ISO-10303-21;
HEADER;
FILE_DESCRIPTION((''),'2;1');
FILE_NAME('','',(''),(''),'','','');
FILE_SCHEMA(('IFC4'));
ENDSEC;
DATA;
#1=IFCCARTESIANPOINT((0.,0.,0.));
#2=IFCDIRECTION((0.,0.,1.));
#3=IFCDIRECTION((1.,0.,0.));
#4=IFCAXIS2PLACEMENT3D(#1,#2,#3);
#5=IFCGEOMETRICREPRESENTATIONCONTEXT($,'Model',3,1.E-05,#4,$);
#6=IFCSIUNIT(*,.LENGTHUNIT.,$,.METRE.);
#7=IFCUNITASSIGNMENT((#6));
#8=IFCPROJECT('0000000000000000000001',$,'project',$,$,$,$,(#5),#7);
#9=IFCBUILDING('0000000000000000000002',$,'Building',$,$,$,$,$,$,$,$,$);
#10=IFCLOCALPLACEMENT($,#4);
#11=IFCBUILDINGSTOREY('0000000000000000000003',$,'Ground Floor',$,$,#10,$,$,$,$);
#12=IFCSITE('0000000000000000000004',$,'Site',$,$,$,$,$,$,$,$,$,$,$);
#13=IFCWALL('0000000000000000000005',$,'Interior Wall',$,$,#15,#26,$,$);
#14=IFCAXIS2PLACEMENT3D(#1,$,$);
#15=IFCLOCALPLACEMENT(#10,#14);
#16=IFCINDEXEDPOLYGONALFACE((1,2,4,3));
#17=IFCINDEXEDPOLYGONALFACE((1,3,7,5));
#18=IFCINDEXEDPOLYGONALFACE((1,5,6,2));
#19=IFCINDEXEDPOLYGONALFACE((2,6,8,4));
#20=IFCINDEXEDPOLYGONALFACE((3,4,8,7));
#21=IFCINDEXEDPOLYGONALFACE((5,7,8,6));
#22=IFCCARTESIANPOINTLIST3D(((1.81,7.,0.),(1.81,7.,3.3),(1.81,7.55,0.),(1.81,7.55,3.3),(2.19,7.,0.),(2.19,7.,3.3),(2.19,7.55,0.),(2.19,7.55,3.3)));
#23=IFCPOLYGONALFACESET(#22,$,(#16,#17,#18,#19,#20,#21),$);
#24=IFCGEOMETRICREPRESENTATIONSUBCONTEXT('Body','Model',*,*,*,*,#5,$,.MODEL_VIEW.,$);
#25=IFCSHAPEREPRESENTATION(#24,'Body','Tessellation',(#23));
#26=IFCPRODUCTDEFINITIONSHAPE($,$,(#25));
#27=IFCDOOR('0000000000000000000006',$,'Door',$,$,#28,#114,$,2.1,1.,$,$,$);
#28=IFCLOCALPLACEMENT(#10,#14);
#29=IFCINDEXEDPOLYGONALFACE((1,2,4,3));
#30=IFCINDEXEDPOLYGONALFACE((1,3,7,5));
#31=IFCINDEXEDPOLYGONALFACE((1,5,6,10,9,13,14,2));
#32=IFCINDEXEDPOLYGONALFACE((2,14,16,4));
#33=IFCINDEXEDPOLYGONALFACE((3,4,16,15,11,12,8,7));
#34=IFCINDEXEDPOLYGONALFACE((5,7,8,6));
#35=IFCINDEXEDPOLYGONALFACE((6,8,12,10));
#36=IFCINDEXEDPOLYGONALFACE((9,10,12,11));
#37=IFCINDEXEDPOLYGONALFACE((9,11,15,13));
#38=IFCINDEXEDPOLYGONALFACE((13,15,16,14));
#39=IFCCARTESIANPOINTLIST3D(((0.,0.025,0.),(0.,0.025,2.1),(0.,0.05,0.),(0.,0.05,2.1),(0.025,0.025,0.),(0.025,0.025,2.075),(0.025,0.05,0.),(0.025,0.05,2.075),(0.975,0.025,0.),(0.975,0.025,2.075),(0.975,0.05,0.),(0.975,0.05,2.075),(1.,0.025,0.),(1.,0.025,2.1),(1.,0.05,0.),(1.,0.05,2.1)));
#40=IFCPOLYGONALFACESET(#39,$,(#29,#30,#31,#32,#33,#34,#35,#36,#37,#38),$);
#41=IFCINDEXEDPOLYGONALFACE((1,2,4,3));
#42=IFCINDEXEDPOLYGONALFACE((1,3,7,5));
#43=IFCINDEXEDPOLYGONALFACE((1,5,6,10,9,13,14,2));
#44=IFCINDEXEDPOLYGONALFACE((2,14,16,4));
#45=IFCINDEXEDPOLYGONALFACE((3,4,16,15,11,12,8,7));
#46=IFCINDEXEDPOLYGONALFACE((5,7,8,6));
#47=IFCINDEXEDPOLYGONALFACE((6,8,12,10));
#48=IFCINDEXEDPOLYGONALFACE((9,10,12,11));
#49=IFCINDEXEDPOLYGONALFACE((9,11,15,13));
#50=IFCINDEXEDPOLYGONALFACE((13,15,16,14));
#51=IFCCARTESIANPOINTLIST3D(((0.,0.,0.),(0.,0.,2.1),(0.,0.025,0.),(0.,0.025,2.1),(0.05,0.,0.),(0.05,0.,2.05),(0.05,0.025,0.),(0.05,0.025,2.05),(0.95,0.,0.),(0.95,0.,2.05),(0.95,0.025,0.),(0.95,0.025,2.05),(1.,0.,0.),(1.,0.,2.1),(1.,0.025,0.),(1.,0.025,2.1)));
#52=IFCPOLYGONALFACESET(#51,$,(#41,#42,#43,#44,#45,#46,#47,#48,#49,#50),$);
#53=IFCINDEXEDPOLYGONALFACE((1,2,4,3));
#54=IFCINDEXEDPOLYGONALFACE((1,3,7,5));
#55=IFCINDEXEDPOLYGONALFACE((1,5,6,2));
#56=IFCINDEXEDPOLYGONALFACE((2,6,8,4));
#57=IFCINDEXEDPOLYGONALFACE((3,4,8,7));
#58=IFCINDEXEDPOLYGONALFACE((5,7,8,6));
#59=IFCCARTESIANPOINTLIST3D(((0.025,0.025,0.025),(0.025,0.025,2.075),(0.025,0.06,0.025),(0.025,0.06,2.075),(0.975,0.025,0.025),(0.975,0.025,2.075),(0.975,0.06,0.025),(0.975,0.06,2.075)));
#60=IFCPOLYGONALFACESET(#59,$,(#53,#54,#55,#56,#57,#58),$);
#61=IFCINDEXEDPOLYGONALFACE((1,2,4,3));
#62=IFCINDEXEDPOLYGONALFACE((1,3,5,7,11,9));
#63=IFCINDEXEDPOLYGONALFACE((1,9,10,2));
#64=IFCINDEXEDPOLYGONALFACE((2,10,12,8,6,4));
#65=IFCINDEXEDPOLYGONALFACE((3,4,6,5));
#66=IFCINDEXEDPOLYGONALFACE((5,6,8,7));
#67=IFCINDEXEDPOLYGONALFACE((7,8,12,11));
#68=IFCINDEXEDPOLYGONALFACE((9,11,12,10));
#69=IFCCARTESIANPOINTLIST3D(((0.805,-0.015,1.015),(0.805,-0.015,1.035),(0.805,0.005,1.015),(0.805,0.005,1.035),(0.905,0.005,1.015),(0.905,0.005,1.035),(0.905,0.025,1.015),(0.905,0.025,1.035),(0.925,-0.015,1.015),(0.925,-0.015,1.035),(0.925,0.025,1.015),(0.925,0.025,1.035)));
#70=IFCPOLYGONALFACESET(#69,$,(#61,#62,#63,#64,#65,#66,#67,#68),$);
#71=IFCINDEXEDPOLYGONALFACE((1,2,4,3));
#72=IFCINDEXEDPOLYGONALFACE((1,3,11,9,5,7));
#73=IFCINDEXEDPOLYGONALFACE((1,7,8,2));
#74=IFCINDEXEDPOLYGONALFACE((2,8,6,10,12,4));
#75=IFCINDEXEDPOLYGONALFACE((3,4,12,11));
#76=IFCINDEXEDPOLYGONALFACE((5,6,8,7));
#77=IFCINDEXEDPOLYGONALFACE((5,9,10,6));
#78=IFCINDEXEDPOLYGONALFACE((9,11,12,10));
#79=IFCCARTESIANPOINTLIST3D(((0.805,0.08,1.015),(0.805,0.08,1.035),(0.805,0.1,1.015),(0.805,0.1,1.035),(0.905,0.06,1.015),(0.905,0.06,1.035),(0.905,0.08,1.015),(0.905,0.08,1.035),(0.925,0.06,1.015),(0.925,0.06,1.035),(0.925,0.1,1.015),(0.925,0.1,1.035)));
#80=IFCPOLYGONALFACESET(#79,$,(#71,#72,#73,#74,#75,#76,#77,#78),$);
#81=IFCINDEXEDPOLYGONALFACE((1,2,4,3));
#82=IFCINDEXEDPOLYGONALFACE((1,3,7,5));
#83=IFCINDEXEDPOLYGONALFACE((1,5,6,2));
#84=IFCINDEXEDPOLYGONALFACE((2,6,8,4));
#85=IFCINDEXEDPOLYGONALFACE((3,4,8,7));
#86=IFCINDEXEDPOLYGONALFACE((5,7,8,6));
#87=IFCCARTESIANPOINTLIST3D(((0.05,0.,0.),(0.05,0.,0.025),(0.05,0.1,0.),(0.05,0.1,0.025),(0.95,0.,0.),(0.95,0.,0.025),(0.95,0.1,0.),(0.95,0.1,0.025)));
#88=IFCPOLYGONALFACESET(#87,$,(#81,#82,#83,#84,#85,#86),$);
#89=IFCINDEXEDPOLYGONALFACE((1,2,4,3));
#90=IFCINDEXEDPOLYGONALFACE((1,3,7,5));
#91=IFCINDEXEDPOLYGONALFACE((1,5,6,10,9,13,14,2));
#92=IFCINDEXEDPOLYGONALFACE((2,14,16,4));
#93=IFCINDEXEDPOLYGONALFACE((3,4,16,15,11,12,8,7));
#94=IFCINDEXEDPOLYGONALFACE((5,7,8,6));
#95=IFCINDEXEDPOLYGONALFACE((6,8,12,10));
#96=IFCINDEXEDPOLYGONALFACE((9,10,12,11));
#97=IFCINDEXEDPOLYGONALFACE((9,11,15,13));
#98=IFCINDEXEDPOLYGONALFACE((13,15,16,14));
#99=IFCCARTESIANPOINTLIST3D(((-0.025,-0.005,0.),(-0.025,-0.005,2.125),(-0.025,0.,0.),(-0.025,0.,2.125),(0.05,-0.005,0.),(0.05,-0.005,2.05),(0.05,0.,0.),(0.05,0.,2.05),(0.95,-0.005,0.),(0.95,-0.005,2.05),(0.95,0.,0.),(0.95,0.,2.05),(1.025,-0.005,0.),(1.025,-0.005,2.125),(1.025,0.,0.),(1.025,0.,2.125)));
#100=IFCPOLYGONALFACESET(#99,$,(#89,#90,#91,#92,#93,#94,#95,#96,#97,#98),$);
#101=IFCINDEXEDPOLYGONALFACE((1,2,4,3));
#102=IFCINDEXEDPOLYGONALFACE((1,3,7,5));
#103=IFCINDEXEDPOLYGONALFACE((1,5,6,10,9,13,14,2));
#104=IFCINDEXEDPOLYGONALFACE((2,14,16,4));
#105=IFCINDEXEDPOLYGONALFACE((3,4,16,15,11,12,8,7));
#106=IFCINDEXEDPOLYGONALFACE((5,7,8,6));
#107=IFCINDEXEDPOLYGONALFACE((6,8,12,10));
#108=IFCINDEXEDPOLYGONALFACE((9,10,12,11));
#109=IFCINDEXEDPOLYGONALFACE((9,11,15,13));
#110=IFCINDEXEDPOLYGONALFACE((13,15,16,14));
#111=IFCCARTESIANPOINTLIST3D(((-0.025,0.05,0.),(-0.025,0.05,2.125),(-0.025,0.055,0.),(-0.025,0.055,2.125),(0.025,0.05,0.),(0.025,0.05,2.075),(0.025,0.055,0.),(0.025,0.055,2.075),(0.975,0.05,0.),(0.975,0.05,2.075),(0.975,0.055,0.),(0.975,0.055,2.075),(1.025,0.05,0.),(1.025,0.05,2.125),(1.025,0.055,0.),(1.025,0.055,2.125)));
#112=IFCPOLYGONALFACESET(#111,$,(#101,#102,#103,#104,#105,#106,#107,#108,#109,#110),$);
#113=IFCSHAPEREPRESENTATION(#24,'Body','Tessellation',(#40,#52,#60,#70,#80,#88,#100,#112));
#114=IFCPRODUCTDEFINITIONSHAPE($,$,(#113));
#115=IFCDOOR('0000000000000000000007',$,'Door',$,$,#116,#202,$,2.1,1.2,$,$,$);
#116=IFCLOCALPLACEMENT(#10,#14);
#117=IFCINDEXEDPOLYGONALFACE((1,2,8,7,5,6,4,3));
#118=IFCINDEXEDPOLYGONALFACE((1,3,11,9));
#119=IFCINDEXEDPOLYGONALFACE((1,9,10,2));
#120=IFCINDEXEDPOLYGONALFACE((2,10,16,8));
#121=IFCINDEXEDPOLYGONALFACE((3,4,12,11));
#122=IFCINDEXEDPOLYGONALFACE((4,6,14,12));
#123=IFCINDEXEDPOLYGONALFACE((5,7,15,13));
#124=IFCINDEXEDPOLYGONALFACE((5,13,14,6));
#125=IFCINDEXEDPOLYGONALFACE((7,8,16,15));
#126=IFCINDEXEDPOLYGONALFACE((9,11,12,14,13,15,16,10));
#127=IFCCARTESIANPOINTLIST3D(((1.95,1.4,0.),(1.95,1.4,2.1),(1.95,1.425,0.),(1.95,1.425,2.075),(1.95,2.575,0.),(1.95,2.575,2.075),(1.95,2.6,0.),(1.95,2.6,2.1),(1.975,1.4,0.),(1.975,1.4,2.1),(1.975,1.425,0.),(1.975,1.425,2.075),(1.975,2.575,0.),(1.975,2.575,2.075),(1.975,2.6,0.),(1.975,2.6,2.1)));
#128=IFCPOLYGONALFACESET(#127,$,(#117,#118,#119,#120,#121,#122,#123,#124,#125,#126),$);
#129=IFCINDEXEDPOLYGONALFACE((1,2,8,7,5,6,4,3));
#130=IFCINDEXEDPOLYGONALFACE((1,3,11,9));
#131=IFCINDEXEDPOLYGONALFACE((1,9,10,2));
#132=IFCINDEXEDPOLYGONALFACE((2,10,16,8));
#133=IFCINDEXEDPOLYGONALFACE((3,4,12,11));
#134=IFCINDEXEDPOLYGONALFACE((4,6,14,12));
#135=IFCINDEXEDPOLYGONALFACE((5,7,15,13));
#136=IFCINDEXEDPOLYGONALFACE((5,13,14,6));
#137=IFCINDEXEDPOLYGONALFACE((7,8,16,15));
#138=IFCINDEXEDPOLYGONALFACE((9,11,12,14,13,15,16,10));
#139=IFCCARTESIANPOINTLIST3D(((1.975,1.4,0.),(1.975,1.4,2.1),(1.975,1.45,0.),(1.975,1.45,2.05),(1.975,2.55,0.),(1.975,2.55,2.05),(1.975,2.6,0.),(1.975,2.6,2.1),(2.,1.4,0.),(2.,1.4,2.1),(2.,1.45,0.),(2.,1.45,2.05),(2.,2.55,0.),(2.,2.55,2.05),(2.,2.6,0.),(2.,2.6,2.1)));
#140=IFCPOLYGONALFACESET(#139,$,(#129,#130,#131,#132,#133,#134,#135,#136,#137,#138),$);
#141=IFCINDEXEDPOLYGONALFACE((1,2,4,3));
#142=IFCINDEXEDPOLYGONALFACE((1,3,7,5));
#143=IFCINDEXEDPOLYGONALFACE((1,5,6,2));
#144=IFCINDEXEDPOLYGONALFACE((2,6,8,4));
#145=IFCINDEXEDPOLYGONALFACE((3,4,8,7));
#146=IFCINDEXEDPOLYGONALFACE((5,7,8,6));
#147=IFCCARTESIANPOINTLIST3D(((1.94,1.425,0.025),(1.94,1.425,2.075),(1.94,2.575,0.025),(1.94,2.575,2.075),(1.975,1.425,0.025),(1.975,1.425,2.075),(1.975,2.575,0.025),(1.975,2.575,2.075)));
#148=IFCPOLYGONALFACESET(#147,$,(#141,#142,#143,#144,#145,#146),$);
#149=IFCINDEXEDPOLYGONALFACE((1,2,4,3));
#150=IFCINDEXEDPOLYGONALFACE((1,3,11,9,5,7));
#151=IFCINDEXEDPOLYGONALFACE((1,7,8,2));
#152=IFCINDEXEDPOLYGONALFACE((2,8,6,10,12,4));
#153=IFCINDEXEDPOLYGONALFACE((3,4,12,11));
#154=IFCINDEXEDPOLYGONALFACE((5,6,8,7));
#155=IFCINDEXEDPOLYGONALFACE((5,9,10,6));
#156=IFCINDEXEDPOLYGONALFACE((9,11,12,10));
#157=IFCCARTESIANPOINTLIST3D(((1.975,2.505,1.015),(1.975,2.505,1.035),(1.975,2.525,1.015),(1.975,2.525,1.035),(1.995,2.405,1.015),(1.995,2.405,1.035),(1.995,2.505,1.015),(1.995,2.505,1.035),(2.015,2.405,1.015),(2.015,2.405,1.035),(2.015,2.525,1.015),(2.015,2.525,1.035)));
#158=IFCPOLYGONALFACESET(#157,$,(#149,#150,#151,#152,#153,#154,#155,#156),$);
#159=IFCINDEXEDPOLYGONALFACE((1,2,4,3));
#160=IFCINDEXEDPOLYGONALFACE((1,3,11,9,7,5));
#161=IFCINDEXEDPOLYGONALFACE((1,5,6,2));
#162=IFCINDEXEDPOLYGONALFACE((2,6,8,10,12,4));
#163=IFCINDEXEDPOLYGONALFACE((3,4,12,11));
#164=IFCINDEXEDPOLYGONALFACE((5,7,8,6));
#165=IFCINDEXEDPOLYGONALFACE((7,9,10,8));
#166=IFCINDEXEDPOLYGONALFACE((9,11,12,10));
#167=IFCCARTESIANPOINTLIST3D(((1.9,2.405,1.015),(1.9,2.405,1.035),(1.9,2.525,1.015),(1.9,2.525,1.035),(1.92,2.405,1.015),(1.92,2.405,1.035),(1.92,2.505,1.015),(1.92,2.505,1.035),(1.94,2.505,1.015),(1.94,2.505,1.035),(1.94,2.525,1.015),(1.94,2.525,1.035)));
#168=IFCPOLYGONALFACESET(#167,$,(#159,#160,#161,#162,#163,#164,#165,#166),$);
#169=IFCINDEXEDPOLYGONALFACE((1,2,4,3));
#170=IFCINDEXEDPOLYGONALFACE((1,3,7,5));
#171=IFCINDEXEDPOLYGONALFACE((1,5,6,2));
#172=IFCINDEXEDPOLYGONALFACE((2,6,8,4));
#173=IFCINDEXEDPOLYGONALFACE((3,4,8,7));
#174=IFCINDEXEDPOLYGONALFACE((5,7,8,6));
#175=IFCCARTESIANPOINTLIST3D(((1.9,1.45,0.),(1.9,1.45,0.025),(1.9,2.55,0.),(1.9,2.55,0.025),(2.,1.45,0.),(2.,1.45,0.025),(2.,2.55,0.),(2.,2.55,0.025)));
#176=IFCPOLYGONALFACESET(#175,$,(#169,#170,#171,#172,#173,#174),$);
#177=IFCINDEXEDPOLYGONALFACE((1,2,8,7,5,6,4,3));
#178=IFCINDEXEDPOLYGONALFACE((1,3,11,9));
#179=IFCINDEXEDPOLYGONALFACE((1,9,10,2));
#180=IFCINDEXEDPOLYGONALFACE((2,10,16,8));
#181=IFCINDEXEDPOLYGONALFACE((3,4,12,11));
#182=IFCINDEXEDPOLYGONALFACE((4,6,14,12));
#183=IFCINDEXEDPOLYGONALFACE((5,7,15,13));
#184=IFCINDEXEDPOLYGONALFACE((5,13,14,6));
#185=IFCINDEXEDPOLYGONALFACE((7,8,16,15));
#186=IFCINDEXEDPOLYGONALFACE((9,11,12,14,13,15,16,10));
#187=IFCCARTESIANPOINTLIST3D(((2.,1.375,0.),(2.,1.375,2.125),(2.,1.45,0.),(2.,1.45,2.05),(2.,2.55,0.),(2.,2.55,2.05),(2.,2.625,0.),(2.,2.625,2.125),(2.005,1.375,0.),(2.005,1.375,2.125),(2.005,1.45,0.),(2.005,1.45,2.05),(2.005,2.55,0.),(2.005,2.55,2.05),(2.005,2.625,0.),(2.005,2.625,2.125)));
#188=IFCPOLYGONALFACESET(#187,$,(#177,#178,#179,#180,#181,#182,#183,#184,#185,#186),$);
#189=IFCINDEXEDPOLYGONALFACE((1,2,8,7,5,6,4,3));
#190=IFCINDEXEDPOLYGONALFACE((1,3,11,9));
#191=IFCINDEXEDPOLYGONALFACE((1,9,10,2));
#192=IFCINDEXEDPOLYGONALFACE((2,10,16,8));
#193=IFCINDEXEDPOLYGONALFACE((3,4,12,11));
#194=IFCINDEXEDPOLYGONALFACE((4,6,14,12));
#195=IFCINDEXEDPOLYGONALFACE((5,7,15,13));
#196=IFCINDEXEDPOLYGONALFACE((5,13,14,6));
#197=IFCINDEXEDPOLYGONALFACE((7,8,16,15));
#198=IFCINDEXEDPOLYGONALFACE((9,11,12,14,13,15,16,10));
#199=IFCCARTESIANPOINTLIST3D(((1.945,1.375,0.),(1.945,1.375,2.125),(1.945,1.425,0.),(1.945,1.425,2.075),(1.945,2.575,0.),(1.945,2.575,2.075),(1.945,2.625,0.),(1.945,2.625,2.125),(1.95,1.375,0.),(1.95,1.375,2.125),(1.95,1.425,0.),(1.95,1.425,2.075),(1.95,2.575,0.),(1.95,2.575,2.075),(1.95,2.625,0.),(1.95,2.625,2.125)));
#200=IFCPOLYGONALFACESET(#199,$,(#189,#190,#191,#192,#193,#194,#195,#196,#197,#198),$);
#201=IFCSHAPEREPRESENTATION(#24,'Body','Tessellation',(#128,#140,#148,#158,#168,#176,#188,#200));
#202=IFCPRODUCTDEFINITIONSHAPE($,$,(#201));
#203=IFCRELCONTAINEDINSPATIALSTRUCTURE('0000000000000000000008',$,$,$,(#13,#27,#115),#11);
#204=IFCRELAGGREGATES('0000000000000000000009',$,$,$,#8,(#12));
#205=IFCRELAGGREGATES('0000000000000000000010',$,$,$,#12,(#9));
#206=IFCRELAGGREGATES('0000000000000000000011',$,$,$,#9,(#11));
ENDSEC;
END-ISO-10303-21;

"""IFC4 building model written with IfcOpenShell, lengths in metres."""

from ifc_helpers import new_model, si_unit, frame, origin_with_axes, place, context, subcontext, project, spatial, line, indexed_curve, outline, extrude, element, save


model = new_model("IFC4")

# Units and contexts
model_context = context("Model", 3, precision=1e-05, world=origin_with_axes())
body_context = subcontext(model_context, "Body", "Model", "MODEL_VIEW")
ifc_project = project(units=[si_unit("LENGTHUNIT", "METRE")], contexts=[model_context])

# Site, building, storey
site = spatial("IfcSite", under=ifc_project, Name="Site")
building = spatial("IfcBuilding", under=site, Name="Building")
storey_placement = place(None, origin_with_axes())
storey = spatial("IfcBuildingStorey", under=building, at=storey_placement, Name="Ground Floor")

# Wall
wall_1_placement = place(storey_placement, frame((2.0, 7.55, 0.0), z_axis=(0.0, 0.0, 1.0), x_axis=(0.0, -1.0, 0.0)))
element("IfcWall", 1, at=wall_1_placement, inside=storey, Name="Interior Wall", context=body_context, shape_type="SweptSolid", body=[
    extrude(outline(indexed_curve([(0.0, 0.0), (0.0, 0.38), (0.55, 0.38), (0.55, 0.0), (0.0, 0.0)], self_intersect=False)), frame((0.0, -0.19, 0.0), z_axis=(0.0, 0.0, 1.0), x_axis=(1.0, 0.0, 0.0)), (0.0, 0.0, 1.0), 3.3),
])

# Doors
door_1_placement = place(storey_placement, origin_with_axes())
element("IfcDoor", 2, at=door_1_placement, inside=storey, Name="Door", OverallHeight=2.1, OverallWidth=1.0, context=body_context, shape_type="SweptSolid", body=[
    extrude(outline(indexed_curve([(0.0, 0.0), (0.0, 2.1), (1.0, 2.1), (1.0, 0.0), (0.975, 0.0), (0.975, 2.075), (0.025, 2.075), (0.025, 0.0)], segments=[line(1, 2, 3, 4, 5, 6, 7, 8, 1)])), frame((0.0, 0.025, 0.0), z_axis=(0.0, -1.0, 0.0), x_axis=(1.0, 0.0, 0.0)), (0.0, 0.0, -1.0), 0.025),
    extrude(outline(indexed_curve([(0.0, 0.0), (0.0, 2.1), (1.0, 2.1), (1.0, 0.0), (0.95, 0.0), (0.95, 2.05), (0.05, 2.05), (0.05, 0.0)], segments=[line(1, 2, 3, 4, 5, 6, 7, 8, 1)])), frame((0.0, 0.0, 0.0), z_axis=(0.0, -1.0, 0.0), x_axis=(1.0, 0.0, 0.0)), (0.0, 0.0, -1.0), 0.025),
    extrude(outline(indexed_curve([(0.0, 0.0), (0.95, 0.0), (0.95, 0.035), (0.0, 0.035)], segments=[line(1, 2, 3, 4, 1)])), frame((0.025, 0.025, 0.025), z_axis=(0.0, 0.0, 1.0), x_axis=(1.0, 0.0, 0.0)), (0.0, 0.0, 1.0), 2.05),
    extrude(outline(indexed_curve([(0.0, 0.0), (0.0, -0.04), (-0.12, -0.04), (-0.12, -0.02), (-0.02, -0.02), (-0.02, 0.0)], segments=[line(1, 2, 3, 4, 5, 6, 1)])), frame((0.925, 0.025, 1.015), z_axis=(0.0, 0.0, 1.0), x_axis=(1.0, 0.0, 0.0)), (0.0, 0.0, 1.0), 0.02),
    extrude(outline(indexed_curve([(0.0, 0.0), (0.0, 0.04), (-0.12, 0.04), (-0.12, 0.02), (-0.02, 0.02), (-0.02, 0.0)], segments=[line(1, 2, 3, 4, 5, 6, 1)])), frame((0.925, 0.06, 1.015), z_axis=(0.0, 0.0, 1.0), x_axis=(1.0, 0.0, 0.0)), (0.0, 0.0, 1.0), 0.02),
    extrude(outline(indexed_curve([(0.0, 0.0), (0.9, 0.0), (0.9, 0.1), (0.0, 0.1)], segments=[line(1, 2, 3, 4, 1)])), frame((0.05, 0.0, 0.0), z_axis=(0.0, 0.0, 1.0), x_axis=(1.0, 0.0, 0.0)), (0.0, 0.0, 1.0), 0.025),
    extrude(outline(indexed_curve([(0.0, 0.0), (0.0, 2.125), (1.05, 2.125), (1.05, 0.0), (0.975, 0.0), (0.975, 2.05), (0.075, 2.05), (0.075, 0.0)], segments=[line(1, 2, 3, 4, 5, 6, 7, 8, 1)])), frame((-0.025, -0.005, 0.0), z_axis=(0.0, -1.0, 0.0), x_axis=(1.0, 0.0, 0.0)), (0.0, 0.0, -1.0), 0.005),
    extrude(outline(indexed_curve([(0.0, 0.0), (0.0, 2.125), (1.05, 2.125), (1.05, 0.0), (1.0, 0.0), (1.0, 2.075), (0.05, 2.075), (0.05, 0.0)], segments=[line(1, 2, 3, 4, 5, 6, 7, 8, 1)])), frame((-0.025, 0.05, 0.0), z_axis=(0.0, -1.0, 0.0), x_axis=(1.0, 0.0, 0.0)), (0.0, 0.0, -1.0), 0.005),
])
door_2_placement = place(storey_placement, frame((2.0, 1.4, 0.0), z_axis=(0.0, 0.0, 1.0), x_axis=(0.0, 1.0, 0.0)))
element("IfcDoor", 3, at=door_2_placement, inside=storey, Name="Door", OverallHeight=2.1, OverallWidth=1.2, context=body_context, shape_type="SweptSolid", body=[
    extrude(outline(indexed_curve([(0.0, 0.0), (0.0, 2.1), (1.2, 2.1), (1.2, 0.0), (1.175, 0.0), (1.175, 2.075), (0.025, 2.075), (0.025, 0.0)], segments=[line(1, 2, 3, 4, 5, 6, 7, 8, 1)])), frame((0.0, 0.025, 0.0), z_axis=(0.0, -1.0, 0.0), x_axis=(1.0, 0.0, 0.0)), (0.0, 0.0, -1.0), 0.025),
    extrude(outline(indexed_curve([(0.0, 0.0), (0.0, 2.1), (1.2, 2.1), (1.2, 0.0), (1.15, 0.0), (1.15, 2.05), (0.05, 2.05), (0.05, 0.0)], segments=[line(1, 2, 3, 4, 5, 6, 7, 8, 1)])), frame((0.0, 0.0, 0.0), z_axis=(0.0, -1.0, 0.0), x_axis=(1.0, 0.0, 0.0)), (0.0, 0.0, -1.0), 0.025),
    extrude(outline(indexed_curve([(0.0, 0.0), (1.15, 0.0), (1.15, 0.035), (0.0, 0.035)], segments=[line(1, 2, 3, 4, 1)])), frame((0.025, 0.025, 0.025), z_axis=(0.0, 0.0, 1.0), x_axis=(1.0, 0.0, 0.0)), (0.0, 0.0, 1.0), 2.05),
    extrude(outline(indexed_curve([(0.0, 0.0), (0.0, -0.04), (-0.12, -0.04), (-0.12, -0.02), (-0.02, -0.02), (-0.02, 0.0)], segments=[line(1, 2, 3, 4, 5, 6, 1)])), frame((1.125, 0.025, 1.015), z_axis=(0.0, 0.0, 1.0), x_axis=(1.0, 0.0, 0.0)), (0.0, 0.0, 1.0), 0.02),
    extrude(outline(indexed_curve([(0.0, 0.0), (0.0, 0.04), (-0.12, 0.04), (-0.12, 0.02), (-0.02, 0.02), (-0.02, 0.0)], segments=[line(1, 2, 3, 4, 5, 6, 1)])), frame((1.125, 0.06, 1.015), z_axis=(0.0, 0.0, 1.0), x_axis=(1.0, 0.0, 0.0)), (0.0, 0.0, 1.0), 0.02),
    extrude(outline(indexed_curve([(0.0, 0.0), (1.1, 0.0), (1.1, 0.1), (0.0, 0.1)], segments=[line(1, 2, 3, 4, 1)])), frame((0.05, 0.0, 0.0), z_axis=(0.0, 0.0, 1.0), x_axis=(1.0, 0.0, 0.0)), (0.0, 0.0, 1.0), 0.025),
    extrude(outline(indexed_curve([(0.0, 0.0), (0.0, 2.125), (1.25, 2.125), (1.25, 0.0), (1.175, 0.0), (1.175, 2.05), (0.075, 2.05), (0.075, 0.0)], segments=[line(1, 2, 3, 4, 5, 6, 7, 8, 1)])), frame((-0.025, -0.005, 0.0), z_axis=(0.0, -1.0, 0.0), x_axis=(1.0, 0.0, 0.0)), (0.0, 0.0, -1.0), 0.005),
    extrude(outline(indexed_curve([(0.0, 0.0), (0.0, 2.125), (1.25, 2.125), (1.25, 0.0), (1.2, 0.0), (1.2, 2.075), (0.05, 2.075), (0.05, 0.0)], segments=[line(1, 2, 3, 4, 5, 6, 7, 8, 1)])), frame((-0.025, 0.05, 0.0), z_axis=(0.0, -1.0, 0.0), x_axis=(1.0, 0.0, 0.0)), (0.0, 0.0, -1.0), 0.005),
])

save(model, "model.ifc")
